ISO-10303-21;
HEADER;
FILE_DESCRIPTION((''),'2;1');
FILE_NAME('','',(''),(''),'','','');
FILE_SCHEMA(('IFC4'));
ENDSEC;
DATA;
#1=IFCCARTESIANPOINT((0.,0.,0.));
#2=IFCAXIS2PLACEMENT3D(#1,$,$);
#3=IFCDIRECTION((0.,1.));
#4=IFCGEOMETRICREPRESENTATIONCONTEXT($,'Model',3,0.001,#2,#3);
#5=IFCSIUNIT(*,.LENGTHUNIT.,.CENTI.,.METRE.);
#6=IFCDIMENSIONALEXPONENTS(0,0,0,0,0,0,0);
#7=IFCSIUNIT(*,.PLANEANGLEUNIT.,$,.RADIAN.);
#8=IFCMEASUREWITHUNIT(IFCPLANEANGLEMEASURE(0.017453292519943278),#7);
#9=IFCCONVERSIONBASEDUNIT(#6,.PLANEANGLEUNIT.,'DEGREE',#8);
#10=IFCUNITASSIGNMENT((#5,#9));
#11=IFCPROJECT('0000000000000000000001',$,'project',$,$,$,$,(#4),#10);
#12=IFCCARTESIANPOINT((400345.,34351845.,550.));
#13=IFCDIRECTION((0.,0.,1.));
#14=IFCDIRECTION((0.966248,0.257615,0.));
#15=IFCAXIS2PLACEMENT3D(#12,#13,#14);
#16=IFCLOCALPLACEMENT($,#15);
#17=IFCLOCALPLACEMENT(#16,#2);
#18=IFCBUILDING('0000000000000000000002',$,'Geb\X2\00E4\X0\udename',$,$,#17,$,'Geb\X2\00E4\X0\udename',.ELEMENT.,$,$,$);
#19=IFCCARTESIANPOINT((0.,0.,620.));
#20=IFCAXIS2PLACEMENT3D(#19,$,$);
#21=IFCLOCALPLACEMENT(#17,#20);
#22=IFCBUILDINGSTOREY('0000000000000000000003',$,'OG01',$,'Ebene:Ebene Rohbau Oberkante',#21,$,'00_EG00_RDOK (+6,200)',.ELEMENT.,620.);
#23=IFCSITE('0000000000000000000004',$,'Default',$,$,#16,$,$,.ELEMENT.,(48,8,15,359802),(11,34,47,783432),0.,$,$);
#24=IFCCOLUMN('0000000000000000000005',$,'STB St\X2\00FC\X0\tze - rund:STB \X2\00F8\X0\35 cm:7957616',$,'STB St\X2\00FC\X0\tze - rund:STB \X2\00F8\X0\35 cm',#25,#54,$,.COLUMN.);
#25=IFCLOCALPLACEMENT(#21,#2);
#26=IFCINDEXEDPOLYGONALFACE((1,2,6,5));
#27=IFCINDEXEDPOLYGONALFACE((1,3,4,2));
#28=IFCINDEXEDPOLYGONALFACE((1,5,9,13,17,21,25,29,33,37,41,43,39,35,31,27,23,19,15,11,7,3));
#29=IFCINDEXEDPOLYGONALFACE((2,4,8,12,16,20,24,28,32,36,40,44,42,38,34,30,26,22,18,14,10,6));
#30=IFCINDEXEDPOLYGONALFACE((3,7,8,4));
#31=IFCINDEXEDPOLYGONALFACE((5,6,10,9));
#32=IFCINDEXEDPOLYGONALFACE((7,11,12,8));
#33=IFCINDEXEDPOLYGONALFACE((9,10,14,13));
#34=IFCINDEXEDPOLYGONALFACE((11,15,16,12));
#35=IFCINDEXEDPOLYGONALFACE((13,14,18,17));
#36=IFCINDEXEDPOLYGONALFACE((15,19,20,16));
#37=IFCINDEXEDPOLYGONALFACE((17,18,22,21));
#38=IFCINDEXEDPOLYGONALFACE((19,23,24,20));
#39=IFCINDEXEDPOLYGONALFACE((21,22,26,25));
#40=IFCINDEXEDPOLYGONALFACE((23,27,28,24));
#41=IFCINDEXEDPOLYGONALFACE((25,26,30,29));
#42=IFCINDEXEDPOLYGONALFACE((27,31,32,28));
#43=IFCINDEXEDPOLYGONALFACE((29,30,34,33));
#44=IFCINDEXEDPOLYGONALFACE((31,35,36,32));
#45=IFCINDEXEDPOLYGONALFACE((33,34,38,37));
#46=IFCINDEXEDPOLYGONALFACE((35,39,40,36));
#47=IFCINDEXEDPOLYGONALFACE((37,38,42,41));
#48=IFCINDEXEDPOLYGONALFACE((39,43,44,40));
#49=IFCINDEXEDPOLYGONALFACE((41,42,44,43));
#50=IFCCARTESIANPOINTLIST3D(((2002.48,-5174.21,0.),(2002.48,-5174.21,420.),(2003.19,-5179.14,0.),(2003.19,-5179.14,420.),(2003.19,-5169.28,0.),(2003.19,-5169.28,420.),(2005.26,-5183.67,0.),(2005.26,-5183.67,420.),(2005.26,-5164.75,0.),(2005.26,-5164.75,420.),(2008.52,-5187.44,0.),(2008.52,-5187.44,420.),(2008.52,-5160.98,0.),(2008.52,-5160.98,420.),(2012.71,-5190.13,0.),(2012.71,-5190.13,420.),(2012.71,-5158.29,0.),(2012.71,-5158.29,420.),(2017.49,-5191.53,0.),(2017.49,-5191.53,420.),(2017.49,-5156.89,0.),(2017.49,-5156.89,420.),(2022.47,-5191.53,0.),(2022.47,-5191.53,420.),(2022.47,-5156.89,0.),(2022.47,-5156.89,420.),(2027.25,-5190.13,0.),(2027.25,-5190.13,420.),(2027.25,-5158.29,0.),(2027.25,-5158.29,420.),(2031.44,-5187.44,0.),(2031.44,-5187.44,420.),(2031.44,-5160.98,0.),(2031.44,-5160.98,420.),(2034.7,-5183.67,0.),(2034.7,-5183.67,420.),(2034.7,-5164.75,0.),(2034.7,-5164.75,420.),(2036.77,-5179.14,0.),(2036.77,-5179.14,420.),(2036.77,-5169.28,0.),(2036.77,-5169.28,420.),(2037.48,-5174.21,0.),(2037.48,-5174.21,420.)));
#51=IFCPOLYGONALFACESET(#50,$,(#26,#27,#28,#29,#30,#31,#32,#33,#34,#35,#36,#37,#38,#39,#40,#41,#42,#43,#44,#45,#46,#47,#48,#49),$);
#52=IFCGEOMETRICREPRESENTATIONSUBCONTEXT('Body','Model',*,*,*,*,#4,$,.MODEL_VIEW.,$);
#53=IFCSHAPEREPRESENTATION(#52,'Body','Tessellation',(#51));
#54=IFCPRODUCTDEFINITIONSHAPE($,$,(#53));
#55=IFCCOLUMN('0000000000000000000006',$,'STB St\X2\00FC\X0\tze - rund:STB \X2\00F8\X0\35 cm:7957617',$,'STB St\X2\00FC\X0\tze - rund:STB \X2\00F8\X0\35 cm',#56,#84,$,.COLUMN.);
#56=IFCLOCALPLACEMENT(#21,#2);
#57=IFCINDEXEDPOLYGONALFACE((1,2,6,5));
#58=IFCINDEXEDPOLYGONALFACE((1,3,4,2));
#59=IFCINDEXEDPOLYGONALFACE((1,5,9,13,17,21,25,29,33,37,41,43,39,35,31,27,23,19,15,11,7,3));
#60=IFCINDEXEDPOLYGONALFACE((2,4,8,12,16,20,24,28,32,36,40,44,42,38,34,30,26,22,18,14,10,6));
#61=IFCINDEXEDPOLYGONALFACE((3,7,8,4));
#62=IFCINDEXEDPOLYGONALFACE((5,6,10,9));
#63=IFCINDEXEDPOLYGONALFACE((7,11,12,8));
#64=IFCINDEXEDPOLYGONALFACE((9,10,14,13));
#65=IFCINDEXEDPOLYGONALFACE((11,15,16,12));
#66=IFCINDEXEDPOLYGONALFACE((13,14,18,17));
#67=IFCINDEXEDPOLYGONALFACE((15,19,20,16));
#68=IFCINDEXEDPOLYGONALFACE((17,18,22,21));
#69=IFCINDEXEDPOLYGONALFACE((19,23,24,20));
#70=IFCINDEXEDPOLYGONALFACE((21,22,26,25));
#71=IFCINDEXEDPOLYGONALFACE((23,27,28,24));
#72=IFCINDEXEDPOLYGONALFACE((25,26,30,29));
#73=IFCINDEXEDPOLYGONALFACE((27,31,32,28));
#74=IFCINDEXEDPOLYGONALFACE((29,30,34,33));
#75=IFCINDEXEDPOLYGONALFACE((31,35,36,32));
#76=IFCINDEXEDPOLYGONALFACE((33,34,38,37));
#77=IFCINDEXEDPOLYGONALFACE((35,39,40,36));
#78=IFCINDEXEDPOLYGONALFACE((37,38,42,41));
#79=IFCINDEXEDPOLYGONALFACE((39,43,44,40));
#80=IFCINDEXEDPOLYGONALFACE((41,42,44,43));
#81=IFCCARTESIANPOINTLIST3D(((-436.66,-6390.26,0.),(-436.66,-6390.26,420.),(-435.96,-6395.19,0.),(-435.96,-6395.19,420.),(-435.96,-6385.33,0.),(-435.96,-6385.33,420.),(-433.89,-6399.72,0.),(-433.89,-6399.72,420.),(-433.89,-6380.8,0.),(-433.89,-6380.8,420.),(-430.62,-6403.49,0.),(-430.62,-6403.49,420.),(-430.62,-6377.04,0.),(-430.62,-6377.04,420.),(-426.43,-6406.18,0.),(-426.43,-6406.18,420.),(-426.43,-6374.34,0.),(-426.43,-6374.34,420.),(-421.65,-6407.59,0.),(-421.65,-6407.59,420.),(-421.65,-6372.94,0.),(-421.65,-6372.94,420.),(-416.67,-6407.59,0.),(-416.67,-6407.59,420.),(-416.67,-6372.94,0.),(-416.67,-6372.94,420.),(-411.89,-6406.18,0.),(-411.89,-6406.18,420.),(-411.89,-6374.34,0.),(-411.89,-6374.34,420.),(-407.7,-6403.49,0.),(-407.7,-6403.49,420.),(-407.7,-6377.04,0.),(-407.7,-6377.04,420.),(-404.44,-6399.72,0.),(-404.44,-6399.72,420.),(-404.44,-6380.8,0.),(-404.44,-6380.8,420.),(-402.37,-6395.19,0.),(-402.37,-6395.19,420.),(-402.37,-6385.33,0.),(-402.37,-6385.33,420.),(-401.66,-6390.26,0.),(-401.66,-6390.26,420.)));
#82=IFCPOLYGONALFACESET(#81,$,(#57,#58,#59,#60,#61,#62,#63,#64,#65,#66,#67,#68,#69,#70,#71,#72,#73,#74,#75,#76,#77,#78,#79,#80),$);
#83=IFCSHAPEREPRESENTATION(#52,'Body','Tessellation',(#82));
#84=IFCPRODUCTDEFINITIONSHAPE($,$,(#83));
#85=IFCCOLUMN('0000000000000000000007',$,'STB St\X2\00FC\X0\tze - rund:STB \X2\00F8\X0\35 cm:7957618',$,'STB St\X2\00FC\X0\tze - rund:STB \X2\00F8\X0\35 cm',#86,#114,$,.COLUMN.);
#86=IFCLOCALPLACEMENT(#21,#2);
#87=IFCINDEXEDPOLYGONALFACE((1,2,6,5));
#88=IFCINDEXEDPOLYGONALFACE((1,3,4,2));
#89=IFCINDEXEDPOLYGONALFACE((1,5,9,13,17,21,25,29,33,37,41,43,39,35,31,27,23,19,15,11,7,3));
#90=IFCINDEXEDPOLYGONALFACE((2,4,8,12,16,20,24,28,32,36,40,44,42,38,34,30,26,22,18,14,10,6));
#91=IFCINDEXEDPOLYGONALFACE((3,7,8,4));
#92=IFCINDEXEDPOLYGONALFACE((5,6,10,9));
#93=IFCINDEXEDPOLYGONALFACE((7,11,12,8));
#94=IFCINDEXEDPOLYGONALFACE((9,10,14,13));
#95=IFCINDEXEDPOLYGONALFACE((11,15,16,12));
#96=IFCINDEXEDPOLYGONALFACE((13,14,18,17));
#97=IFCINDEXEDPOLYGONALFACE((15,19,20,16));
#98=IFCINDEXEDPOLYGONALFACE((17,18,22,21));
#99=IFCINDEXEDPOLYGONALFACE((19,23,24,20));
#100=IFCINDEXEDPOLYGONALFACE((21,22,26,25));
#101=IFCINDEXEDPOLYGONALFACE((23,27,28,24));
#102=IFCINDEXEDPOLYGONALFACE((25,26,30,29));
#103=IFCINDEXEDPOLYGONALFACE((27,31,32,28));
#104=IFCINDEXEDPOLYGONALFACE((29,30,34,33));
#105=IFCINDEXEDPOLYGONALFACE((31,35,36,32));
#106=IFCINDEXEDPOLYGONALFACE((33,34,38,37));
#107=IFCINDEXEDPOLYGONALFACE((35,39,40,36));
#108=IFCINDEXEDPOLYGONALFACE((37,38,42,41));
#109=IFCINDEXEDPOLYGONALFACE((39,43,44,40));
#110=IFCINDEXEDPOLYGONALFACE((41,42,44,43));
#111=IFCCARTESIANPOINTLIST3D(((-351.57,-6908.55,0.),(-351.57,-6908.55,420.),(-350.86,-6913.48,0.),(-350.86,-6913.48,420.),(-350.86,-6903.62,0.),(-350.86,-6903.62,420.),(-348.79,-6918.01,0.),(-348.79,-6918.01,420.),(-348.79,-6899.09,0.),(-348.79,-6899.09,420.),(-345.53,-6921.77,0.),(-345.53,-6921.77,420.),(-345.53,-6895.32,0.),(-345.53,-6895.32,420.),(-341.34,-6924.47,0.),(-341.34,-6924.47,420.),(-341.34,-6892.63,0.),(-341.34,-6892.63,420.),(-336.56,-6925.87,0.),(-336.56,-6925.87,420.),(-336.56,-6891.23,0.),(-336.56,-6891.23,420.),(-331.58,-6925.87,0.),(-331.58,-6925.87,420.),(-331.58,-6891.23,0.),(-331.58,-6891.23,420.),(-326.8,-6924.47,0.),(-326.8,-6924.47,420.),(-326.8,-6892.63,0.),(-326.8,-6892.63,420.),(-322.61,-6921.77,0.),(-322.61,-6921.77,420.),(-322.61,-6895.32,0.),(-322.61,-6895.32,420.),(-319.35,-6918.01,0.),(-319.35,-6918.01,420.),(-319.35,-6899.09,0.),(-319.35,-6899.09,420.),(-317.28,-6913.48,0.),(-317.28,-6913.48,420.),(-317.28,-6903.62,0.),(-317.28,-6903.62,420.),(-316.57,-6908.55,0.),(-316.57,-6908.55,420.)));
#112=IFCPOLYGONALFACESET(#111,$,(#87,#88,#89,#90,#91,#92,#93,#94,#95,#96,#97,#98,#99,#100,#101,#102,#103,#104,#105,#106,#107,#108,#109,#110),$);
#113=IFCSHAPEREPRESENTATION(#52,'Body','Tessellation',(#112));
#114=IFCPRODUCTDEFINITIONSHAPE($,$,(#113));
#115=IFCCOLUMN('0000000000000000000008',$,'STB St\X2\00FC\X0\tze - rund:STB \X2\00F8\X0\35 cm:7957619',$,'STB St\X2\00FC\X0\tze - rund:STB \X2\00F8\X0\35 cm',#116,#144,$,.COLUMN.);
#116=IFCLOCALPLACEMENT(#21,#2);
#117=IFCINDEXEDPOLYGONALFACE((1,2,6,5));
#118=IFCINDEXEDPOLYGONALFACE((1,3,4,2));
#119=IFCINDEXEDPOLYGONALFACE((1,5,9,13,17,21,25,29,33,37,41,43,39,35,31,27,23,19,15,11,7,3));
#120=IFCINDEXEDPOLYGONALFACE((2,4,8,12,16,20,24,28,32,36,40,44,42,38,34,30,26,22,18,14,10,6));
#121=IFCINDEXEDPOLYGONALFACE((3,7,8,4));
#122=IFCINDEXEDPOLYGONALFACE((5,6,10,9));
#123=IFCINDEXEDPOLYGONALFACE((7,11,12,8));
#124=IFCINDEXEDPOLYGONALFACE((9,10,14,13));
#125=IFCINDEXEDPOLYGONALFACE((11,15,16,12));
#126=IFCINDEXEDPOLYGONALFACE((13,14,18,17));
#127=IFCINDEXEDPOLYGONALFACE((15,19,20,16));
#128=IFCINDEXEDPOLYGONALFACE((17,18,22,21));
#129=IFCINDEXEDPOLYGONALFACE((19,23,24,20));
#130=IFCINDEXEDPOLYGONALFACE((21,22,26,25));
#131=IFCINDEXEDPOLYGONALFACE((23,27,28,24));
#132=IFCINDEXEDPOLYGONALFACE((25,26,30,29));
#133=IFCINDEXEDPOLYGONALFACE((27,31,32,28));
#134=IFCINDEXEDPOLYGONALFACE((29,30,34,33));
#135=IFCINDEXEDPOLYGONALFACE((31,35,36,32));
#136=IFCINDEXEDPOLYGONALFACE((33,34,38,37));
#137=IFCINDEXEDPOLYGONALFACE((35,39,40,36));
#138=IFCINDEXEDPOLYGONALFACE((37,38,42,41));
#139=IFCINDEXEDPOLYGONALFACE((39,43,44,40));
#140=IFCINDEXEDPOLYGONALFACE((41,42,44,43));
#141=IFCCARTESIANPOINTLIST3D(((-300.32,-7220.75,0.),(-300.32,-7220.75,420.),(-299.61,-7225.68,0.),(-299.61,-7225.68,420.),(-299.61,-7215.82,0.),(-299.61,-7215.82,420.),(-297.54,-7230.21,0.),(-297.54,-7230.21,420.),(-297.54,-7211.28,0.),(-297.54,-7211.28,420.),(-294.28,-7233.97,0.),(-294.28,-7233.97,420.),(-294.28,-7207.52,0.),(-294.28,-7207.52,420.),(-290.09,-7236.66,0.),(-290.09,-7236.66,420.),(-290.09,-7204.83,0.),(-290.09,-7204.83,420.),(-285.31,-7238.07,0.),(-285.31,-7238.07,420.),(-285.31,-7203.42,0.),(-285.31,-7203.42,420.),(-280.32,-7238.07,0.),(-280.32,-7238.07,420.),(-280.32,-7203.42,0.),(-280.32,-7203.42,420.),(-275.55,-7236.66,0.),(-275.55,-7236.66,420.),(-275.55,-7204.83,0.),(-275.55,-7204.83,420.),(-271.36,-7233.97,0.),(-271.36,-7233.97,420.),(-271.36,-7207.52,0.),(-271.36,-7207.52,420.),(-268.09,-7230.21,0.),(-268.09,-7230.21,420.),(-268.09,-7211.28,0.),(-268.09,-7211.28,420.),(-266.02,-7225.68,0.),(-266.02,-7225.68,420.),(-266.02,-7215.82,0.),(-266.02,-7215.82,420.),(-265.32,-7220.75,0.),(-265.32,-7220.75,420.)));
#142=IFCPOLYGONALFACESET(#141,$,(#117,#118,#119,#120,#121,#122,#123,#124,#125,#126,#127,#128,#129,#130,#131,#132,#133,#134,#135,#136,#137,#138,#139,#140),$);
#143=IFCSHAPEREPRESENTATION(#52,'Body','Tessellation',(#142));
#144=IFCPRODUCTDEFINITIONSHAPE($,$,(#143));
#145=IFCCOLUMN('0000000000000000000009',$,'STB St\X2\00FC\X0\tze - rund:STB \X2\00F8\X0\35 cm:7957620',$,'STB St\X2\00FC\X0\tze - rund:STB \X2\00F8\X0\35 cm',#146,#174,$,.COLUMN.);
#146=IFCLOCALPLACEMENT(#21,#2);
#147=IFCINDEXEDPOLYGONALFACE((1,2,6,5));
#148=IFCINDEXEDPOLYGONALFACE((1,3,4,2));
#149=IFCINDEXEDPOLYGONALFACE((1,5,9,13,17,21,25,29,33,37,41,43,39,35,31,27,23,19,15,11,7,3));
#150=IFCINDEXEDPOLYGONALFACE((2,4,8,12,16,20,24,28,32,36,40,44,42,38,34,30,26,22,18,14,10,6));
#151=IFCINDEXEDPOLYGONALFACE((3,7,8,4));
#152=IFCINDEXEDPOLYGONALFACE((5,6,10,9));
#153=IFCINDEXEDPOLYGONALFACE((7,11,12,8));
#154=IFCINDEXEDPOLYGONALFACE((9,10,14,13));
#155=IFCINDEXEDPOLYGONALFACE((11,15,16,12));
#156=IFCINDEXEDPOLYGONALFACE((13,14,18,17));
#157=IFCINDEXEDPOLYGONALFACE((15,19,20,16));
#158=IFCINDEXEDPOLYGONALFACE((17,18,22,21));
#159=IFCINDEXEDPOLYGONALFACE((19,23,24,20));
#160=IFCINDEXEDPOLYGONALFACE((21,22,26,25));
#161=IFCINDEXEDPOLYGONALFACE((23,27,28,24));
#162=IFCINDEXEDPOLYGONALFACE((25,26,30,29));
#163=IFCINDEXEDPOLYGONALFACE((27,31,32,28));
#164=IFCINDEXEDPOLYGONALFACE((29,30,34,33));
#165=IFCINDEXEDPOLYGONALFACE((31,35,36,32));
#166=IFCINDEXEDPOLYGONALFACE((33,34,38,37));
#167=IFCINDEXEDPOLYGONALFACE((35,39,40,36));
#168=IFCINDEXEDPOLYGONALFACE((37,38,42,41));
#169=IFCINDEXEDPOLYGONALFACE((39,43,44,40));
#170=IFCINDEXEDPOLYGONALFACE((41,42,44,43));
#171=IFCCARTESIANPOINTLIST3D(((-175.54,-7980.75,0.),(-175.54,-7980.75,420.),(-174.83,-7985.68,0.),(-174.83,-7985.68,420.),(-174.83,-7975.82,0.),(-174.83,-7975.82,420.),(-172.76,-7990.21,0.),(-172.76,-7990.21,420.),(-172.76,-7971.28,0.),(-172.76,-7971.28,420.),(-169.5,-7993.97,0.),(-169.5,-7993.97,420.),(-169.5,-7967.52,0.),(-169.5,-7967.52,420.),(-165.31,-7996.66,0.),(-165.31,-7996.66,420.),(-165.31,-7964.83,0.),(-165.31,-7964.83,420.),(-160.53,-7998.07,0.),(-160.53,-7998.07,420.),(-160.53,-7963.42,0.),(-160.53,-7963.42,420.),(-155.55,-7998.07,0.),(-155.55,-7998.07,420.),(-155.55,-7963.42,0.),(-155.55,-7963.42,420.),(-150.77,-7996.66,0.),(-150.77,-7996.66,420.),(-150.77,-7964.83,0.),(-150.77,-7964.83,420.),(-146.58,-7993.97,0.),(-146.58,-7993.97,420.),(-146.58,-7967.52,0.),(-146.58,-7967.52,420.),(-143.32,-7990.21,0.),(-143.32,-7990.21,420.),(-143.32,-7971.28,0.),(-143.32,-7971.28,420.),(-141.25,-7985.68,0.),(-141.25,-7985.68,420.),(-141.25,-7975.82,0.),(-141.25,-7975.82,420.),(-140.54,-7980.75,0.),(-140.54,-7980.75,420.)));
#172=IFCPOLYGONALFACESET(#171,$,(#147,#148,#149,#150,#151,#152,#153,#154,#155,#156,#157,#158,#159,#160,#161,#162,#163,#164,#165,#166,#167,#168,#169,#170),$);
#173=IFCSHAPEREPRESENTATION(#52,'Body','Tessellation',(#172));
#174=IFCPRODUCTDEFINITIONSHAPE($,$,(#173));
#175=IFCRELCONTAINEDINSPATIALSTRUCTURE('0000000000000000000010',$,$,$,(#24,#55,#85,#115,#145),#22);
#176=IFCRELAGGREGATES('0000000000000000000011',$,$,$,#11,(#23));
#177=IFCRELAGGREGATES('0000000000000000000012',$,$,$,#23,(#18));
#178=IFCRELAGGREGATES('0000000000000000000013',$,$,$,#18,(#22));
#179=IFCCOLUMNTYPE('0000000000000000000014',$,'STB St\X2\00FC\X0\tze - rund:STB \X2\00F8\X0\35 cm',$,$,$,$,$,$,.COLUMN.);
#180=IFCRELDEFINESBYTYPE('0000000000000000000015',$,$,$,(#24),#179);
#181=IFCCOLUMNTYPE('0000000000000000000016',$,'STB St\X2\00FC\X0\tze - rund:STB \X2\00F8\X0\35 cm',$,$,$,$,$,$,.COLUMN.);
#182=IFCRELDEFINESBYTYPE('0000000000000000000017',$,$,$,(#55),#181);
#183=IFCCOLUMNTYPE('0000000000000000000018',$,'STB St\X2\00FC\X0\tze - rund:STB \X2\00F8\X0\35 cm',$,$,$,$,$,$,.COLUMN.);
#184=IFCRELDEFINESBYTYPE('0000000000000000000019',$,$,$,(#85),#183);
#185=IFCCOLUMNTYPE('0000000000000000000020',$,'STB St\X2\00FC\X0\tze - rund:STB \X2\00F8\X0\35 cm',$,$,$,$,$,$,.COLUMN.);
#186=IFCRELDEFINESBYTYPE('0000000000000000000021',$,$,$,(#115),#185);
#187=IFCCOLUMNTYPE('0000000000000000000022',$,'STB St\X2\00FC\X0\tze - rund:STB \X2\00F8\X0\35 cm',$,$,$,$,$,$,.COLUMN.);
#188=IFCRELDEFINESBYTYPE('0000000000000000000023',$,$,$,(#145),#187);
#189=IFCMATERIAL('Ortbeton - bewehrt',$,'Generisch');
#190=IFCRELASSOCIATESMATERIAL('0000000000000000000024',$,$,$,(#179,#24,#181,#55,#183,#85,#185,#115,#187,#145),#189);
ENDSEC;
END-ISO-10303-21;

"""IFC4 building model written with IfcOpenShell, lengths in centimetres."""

from ifc_helpers import new_model, entity, si_unit, converted_unit, direction, frame, origin, place, context, subcontext, project, spatial, arc, indexed_curve, outline, extrude, source, transform, mapped, material, type_object, type_shapes, element, save


model = new_model("IFC4")

# Units and contexts
model_context = context("Model", 3, precision=0.001, world=origin(), true_north=direction((0.0, 1.0)))
body_context = subcontext(model_context, "Body", "Model", "MODEL_VIEW")
ifc_project = project(units=[si_unit("LENGTHUNIT", "METRE", prefix="CENTI"), converted_unit("PLANEANGLEUNIT", "DEGREE", entity("IfcPlaneAngleMeasure", 0.017453292519943278), si_unit("PLANEANGLEUNIT", "RADIAN"), dimensions=[0, 0, 0, 0, 0, 0, 0])], contexts=[model_context])

# Site, building, storey
site_placement = place(None, frame((400345.0, 34351845.0, 550.0), z_axis=(0.0, 0.0, 1.0), x_axis=(0.966248, 0.257615, 0.0)))
site = spatial("IfcSite", under=ifc_project, at=site_placement, Name="Default", CompositionType="ELEMENT", RefLatitude=(48, 8, 15, 359802), RefLongitude=(11, 34, 47, 783432), RefElevation=0.0)
building_placement = place(site_placement, origin())
building = spatial("IfcBuilding", under=site, at=building_placement, Name="Gebäudename", LongName="Gebäudename", CompositionType="ELEMENT")
storey_placement = place(building_placement, frame((0.0, 0.0, 620.0)))
storey = spatial("IfcBuildingStorey", under=building, at=storey_placement, Name="OG01", ObjectType="Ebene:Ebene Rohbau Oberkante", LongName="00_EG00_RDOK (+6,200)", CompositionType="ELEMENT", Elevation=620.0)

# Columns
ifc_material = material(Name="Ortbeton - bewehrt", Category="Generisch")
column_type_1 = type_object("IfcColumnType", Name="STB Stütze - rund:STB ø35 cm", PredefinedType="COLUMN", material=ifc_material)
shared_shape_1 = source(origin(), body_context, "Body", "SweptSolid", [
    extrude(outline(indexed_curve([(-17.5, 0.0), (0.0, -17.5), (17.5, 0.0), (0.0, 17.5)], segments=[arc(1, 2, 3), arc(3, 4, 1)], self_intersect=False)), frame((2019.98, -5174.21, 620.0)), (0.0, 0.0, 1.0), 420.0),
])
type_shapes(column_type_1, [shared_shape_1])
column_1_placement = place(storey_placement, frame((0.0, 0.0, -620.0)))
element("IfcColumn", 1, at=column_1_placement, inside=storey, type_object=column_type_1, material=ifc_material, Name="STB Stütze - rund:STB ø35 cm:7957616", ObjectType="STB Stütze - rund:STB ø35 cm", PredefinedType="COLUMN", context=body_context, shape_type="MappedRepresentation", body=[
    mapped(shared_shape_1, transform((0.0, 0.0, 0.0), scale=1.0)),
])
column_type_2 = type_object("IfcColumnType", Name="STB Stütze - rund:STB ø35 cm", PredefinedType="COLUMN", material=ifc_material)
shared_shape_2 = source(origin(), body_context, "Body", "SweptSolid", [
    extrude(outline(indexed_curve([(-17.5, 0.0), (0.0, -17.5), (17.5, 0.0), (0.0, 17.5)], segments=[arc(1, 2, 3), arc(3, 4, 1)], self_intersect=False)), frame((-419.16, -6390.26, 620.0)), (0.0, 0.0, 1.0), 420.0),
])
type_shapes(column_type_2, [shared_shape_2])
column_2_placement = place(storey_placement, frame((0.0, 0.0, -620.0)))
element("IfcColumn", 2, at=column_2_placement, inside=storey, type_object=column_type_2, material=ifc_material, Name="STB Stütze - rund:STB ø35 cm:7957617", ObjectType="STB Stütze - rund:STB ø35 cm", PredefinedType="COLUMN", context=body_context, shape_type="MappedRepresentation", body=[
    mapped(shared_shape_2, transform((0.0, 0.0, 0.0), scale=1.0)),
])
column_type_3 = type_object("IfcColumnType", Name="STB Stütze - rund:STB ø35 cm", PredefinedType="COLUMN", material=ifc_material)
shared_shape_3 = source(origin(), body_context, "Body", "SweptSolid", [
    extrude(outline(indexed_curve([(-17.5, 0.0), (0.0, -17.5), (17.5, 0.0), (0.0, 17.5)], segments=[arc(1, 2, 3), arc(3, 4, 1)], self_intersect=False)), frame((-334.07, -6908.55, 620.0)), (0.0, 0.0, 1.0), 420.0),
])
type_shapes(column_type_3, [shared_shape_3])
column_3_placement = place(storey_placement, frame((0.0, 0.0, -620.0)))
element("IfcColumn", 3, at=column_3_placement, inside=storey, type_object=column_type_3, material=ifc_material, Name="STB Stütze - rund:STB ø35 cm:7957618", ObjectType="STB Stütze - rund:STB ø35 cm", PredefinedType="COLUMN", context=body_context, shape_type="MappedRepresentation", body=[
    mapped(shared_shape_3, transform((0.0, 0.0, 0.0), scale=1.0)),
])
column_type_4 = type_object("IfcColumnType", Name="STB Stütze - rund:STB ø35 cm", PredefinedType="COLUMN", material=ifc_material)
shared_shape_4 = source(origin(), body_context, "Body", "SweptSolid", [
    extrude(outline(indexed_curve([(-17.5, 0.0), (0.0, -17.5), (17.5, 0.0), (0.0, 17.5)], segments=[arc(1, 2, 3), arc(3, 4, 1)], self_intersect=False)), frame((-282.82, -7220.75, 620.0)), (0.0, 0.0, 1.0), 420.0),
])
type_shapes(column_type_4, [shared_shape_4])
column_4_placement = place(storey_placement, frame((0.0, 0.0, -620.0)))
element("IfcColumn", 4, at=column_4_placement, inside=storey, type_object=column_type_4, material=ifc_material, Name="STB Stütze - rund:STB ø35 cm:7957619", ObjectType="STB Stütze - rund:STB ø35 cm", PredefinedType="COLUMN", context=body_context, shape_type="MappedRepresentation", body=[
    mapped(shared_shape_4, transform((0.0, 0.0, 0.0), scale=1.0)),
])
column_type_5 = type_object("IfcColumnType", Name="STB Stütze - rund:STB ø35 cm", PredefinedType="COLUMN", material=ifc_material)
shared_shape_5 = source(origin(), body_context, "Body", "SweptSolid", [
    extrude(outline(indexed_curve([(-17.5, 0.0), (0.0, -17.5), (17.5, 0.0), (0.0, 17.5)], segments=[arc(1, 2, 3), arc(3, 4, 1)], self_intersect=False)), frame((-158.04, -7980.75, 620.0)), (0.0, 0.0, 1.0), 420.0),
])
type_shapes(column_type_5, [shared_shape_5])
column_5_placement = place(storey_placement, frame((0.0, 0.0, -620.0)))
element("IfcColumn", 5, at=column_5_placement, inside=storey, type_object=column_type_5, material=ifc_material, Name="STB Stütze - rund:STB ø35 cm:7957620", ObjectType="STB Stütze - rund:STB ø35 cm", PredefinedType="COLUMN", context=body_context, shape_type="MappedRepresentation", body=[
    mapped(shared_shape_5, transform((0.0, 0.0, 0.0), scale=1.0)),
])

save(model, "model.ifc")
